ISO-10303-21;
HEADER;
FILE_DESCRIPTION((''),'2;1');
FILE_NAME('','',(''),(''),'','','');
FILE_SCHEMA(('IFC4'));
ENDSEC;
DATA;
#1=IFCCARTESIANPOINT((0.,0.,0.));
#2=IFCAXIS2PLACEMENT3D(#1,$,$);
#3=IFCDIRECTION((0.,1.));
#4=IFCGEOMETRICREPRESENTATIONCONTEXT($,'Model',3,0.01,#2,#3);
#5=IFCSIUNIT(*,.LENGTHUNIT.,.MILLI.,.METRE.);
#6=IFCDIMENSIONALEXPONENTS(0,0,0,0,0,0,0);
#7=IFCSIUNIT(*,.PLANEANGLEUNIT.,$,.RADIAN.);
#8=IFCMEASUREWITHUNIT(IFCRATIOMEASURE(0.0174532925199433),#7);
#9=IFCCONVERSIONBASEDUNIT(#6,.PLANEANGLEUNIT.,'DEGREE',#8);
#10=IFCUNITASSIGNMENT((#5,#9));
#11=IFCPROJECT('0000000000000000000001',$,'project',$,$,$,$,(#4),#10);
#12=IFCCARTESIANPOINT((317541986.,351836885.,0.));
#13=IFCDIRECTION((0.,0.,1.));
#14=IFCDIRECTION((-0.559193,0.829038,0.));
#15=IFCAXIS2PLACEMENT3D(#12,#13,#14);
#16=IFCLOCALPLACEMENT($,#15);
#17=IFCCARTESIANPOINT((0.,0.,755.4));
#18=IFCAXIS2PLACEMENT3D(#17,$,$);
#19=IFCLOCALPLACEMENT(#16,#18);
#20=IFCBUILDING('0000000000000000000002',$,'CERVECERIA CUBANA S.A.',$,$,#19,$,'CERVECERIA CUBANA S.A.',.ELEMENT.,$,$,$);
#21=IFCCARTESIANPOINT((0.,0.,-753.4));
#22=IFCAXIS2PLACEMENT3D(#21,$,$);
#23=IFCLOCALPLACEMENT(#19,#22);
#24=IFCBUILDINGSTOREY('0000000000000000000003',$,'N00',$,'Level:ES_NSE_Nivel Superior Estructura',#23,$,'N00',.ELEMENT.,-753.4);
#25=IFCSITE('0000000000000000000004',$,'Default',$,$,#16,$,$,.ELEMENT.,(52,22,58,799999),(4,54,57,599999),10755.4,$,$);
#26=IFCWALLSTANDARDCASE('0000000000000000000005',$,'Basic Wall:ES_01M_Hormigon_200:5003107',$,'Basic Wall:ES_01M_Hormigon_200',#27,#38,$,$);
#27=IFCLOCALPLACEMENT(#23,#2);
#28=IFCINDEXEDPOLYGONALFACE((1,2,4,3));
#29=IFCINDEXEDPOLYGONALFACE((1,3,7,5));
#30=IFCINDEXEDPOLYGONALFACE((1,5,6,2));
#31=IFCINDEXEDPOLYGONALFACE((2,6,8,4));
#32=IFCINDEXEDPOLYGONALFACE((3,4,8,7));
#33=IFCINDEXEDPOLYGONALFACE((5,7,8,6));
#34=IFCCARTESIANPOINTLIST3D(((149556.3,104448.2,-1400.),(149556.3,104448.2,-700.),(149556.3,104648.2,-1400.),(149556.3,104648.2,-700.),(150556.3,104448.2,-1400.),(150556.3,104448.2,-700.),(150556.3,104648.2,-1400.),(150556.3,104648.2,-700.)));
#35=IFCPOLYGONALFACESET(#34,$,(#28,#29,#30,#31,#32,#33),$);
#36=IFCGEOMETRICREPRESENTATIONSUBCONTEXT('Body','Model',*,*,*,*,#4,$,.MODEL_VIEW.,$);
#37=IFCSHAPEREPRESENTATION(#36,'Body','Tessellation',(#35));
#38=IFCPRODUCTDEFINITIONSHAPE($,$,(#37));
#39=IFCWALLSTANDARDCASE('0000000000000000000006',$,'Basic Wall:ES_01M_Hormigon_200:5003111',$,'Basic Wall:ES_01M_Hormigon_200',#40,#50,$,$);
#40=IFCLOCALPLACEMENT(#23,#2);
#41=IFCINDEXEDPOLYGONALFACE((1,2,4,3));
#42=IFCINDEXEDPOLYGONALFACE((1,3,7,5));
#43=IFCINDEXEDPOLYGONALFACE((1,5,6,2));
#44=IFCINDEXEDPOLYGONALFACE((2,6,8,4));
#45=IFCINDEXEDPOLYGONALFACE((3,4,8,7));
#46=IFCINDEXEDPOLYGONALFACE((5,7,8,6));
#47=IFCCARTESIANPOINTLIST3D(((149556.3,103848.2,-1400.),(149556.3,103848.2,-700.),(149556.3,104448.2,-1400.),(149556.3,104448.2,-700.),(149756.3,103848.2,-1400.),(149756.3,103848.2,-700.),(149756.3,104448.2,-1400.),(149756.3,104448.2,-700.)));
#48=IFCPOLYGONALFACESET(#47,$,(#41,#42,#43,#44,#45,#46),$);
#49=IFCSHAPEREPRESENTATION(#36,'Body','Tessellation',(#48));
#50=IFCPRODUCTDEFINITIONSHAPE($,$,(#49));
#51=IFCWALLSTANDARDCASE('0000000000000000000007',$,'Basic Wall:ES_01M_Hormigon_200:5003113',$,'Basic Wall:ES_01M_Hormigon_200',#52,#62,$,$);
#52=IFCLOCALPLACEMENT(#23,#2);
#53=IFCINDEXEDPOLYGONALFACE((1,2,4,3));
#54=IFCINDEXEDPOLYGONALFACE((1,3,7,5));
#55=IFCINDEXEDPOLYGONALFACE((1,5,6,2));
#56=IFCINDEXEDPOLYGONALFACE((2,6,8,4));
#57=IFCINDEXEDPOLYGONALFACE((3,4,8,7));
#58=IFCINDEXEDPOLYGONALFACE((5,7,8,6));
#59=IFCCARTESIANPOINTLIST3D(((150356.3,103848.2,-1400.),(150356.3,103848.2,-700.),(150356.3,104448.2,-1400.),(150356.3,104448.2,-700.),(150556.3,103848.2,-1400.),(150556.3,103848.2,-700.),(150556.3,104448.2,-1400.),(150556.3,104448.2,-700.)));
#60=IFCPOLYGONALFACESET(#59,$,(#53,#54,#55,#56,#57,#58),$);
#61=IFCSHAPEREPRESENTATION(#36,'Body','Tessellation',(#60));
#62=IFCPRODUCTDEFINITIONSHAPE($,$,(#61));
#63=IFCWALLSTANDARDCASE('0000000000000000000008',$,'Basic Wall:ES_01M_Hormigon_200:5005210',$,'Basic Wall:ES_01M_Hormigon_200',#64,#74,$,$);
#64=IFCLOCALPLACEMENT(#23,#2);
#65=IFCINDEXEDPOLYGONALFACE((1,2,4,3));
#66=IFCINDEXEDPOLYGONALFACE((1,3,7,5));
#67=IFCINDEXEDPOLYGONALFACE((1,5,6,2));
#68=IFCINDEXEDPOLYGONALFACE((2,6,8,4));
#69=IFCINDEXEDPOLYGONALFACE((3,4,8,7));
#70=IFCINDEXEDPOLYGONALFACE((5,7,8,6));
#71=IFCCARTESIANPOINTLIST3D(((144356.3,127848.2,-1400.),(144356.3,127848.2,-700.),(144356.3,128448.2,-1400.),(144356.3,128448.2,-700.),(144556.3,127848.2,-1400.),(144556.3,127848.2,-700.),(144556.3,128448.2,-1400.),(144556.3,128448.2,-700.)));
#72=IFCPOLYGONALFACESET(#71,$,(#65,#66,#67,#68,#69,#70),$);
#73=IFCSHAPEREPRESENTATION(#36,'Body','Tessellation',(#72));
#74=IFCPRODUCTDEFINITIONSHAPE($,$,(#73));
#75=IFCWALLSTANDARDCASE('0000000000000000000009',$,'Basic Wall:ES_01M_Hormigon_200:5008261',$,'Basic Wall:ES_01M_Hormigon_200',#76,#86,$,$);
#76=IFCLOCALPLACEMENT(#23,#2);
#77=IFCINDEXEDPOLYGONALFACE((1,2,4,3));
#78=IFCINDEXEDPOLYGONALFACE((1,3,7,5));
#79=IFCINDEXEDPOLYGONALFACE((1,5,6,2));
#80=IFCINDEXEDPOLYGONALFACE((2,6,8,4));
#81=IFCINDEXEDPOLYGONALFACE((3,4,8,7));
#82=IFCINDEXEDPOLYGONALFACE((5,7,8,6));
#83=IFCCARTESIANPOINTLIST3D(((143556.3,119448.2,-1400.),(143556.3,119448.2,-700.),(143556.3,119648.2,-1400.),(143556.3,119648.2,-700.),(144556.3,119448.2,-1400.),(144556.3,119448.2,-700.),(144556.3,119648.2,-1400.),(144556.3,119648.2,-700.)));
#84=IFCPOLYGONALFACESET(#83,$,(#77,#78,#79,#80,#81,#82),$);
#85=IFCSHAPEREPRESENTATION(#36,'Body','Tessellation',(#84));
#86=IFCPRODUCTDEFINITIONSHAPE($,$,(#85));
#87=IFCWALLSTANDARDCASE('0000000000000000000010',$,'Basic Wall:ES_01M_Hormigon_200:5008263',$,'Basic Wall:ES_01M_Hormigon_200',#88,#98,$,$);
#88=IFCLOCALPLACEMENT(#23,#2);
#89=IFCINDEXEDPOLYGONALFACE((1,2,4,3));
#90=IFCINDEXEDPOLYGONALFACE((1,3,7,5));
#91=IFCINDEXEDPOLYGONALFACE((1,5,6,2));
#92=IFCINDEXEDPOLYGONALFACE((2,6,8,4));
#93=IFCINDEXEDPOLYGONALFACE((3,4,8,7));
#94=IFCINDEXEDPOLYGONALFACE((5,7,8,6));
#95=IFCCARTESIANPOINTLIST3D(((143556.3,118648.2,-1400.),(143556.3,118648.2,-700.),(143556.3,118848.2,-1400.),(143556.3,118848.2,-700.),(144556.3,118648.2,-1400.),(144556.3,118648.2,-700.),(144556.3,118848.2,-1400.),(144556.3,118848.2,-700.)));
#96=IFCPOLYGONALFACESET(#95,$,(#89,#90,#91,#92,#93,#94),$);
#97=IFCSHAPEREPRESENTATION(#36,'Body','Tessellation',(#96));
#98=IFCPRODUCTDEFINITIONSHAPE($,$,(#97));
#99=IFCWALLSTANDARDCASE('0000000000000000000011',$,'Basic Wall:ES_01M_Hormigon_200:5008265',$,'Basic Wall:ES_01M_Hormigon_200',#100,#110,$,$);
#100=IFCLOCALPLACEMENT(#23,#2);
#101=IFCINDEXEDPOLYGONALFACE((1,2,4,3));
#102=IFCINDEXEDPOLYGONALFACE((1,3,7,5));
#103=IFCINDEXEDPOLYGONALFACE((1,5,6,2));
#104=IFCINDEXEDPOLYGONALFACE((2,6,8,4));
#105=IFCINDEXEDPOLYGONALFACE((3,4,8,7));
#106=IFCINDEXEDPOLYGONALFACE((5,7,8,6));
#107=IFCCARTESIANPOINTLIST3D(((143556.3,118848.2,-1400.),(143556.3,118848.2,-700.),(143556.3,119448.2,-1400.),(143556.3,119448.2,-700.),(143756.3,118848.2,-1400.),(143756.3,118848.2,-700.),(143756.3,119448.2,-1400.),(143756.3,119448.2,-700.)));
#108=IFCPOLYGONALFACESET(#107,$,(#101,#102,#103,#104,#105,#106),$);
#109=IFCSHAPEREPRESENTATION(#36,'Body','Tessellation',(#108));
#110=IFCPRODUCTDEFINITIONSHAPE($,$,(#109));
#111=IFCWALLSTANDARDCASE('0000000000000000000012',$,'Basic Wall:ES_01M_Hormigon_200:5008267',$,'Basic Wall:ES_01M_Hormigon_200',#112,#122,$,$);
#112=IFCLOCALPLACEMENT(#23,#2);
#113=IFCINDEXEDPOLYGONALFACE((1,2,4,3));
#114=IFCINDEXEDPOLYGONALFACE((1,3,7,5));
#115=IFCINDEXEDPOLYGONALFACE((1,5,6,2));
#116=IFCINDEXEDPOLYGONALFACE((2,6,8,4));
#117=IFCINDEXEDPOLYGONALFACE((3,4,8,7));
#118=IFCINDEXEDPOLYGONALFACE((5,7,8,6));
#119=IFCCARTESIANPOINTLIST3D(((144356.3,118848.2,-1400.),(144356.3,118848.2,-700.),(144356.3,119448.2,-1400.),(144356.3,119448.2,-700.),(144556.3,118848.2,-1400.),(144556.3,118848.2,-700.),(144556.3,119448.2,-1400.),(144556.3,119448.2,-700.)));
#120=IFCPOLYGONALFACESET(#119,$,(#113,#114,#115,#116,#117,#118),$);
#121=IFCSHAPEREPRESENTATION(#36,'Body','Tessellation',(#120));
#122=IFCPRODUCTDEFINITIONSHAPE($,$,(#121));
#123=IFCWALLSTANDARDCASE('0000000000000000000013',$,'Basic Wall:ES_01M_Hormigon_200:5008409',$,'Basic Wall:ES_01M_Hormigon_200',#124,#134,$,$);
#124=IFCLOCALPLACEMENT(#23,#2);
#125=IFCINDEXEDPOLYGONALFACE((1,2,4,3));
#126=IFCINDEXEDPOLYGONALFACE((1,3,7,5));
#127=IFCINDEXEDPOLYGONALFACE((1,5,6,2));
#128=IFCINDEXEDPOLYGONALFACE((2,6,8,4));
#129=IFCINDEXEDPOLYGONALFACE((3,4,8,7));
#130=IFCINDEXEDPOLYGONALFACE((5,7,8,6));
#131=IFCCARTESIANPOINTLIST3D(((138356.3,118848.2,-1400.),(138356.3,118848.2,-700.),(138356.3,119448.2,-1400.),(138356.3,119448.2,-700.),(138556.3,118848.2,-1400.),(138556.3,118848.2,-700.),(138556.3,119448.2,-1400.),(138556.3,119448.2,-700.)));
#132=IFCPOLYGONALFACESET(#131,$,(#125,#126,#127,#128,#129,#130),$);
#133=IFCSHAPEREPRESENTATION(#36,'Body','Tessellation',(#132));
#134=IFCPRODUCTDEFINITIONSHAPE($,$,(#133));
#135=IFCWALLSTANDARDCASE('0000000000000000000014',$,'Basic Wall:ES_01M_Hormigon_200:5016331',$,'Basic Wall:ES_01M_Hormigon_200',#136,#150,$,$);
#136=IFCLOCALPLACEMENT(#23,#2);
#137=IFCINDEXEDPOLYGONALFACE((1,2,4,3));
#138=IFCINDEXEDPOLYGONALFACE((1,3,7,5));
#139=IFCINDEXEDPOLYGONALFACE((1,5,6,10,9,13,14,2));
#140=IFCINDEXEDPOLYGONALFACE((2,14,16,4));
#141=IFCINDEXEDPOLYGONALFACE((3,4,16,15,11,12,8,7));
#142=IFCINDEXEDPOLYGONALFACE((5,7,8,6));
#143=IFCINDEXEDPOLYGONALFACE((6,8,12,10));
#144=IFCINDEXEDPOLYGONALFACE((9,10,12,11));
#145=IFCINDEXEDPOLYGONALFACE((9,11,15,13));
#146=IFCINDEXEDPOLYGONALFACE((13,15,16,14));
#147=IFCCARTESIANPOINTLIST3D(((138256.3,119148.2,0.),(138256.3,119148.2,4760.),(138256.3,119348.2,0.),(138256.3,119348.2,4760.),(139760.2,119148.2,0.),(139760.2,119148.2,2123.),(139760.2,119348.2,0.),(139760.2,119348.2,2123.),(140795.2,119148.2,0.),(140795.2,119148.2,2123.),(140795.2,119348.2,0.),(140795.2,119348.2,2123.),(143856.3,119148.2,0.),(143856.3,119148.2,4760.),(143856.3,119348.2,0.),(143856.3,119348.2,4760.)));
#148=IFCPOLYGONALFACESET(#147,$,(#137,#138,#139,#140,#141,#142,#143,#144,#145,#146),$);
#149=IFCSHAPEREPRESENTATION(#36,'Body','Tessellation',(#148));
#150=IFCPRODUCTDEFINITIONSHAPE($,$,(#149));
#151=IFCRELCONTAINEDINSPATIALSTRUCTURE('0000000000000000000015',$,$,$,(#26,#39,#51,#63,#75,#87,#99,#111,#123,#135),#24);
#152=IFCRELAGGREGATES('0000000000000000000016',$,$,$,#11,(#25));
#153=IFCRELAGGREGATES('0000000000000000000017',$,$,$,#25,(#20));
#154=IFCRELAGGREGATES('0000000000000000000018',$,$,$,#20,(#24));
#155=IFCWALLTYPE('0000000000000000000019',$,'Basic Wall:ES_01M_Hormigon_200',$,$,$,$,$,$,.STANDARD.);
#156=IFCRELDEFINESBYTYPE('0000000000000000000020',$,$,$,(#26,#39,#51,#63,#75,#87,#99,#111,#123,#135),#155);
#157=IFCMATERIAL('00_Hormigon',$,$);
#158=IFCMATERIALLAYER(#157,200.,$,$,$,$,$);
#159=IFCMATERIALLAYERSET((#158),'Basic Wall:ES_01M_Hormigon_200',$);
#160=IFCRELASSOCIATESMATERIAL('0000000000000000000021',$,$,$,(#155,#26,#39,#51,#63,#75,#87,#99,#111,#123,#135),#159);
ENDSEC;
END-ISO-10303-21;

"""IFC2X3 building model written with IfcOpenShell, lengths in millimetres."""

from ifc_helpers import new_model, entity, si_unit, converted_unit, direction, frame, frame_2d, origin, place, context, subcontext, project, spatial, rectangle, extrude, material, layer, layer_set, layer_usage, type_object, element, save


model = new_model("IFC2X3")

# Units and contexts
model_context = context("Model", 3, precision=0.01, world=origin(), true_north=direction((0.0, 1.0)))
body_context = subcontext(model_context, "Body", "Model", "MODEL_VIEW")
ifc_project = project(units=[si_unit("LENGTHUNIT", "METRE", prefix="MILLI"), converted_unit("PLANEANGLEUNIT", "DEGREE", entity("IfcRatioMeasure", 0.0174532925199433), si_unit("PLANEANGLEUNIT", "RADIAN"), dimensions=[0, 0, 0, 0, 0, 0, 0])], contexts=[model_context])

# Site, building, storey
site_placement = place(None, frame((317541986.0, 351836885.0, 0.0), z_axis=(0.0, 0.0, 1.0), x_axis=(-0.559193, 0.829038, 0.0)))
site = spatial("IfcSite", under=ifc_project, at=site_placement, Name="Default", CompositionType="ELEMENT", RefLatitude=(52, 22, 58, 799999), RefLongitude=(4, 54, 57, 599999), RefElevation=10755.4)
building_placement = place(site_placement, frame((0.0, 0.0, 755.4)))
building = spatial("IfcBuilding", under=site, at=building_placement, Name="CERVECERIA CUBANA S.A.", LongName="CERVECERIA CUBANA S.A.", CompositionType="ELEMENT")
storey_placement = place(building_placement, frame((0.0, 0.0, -753.4)))
storey = spatial("IfcBuildingStorey", under=building, at=storey_placement, Name="N00", ObjectType="Level:ES_NSE_Nivel Superior Estructura", LongName="N00", CompositionType="ELEMENT", Elevation=-753.4)

# Walls
ifc_material = material(Name="00_Hormigon")
ifc_layer_1 = layer(ifc_material, 200.0)
ifc_layer_set_1 = layer_set([ifc_layer_1], Name="Basic Wall:ES_01M_Hormigon_200")
wall_type_1 = type_object("IfcWallType", Name="Basic Wall:ES_01M_Hormigon_200", PredefinedType="STANDARD", material=ifc_layer_set_1)
ifc_layer_usage_1 = layer_usage(ifc_layer_set_1, "AXIS2", "NEGATIVE", 100.0)
wall_1_placement = place(storey_placement, frame((149556.3, 104548.2, -1400.0)))
element("IfcWallStandardCase", 1, at=wall_1_placement, inside=storey, type_object=wall_type_1, material=ifc_layer_usage_1, Name="Basic Wall:ES_01M_Hormigon_200:5003107", ObjectType="Basic Wall:ES_01M_Hormigon_200", context=body_context, shape_type="SweptSolid", body=[
    extrude(rectangle(XDim=1000.0, YDim=200.0, at=frame_2d((500.0, 0.0), x_axis=(-1.0, 0.0))), origin(), (0.0, 0.0, 1.0), 700.0),
])
ifc_layer_usage_2 = layer_usage(ifc_layer_set_1, "AXIS2", "POSITIVE", -100.0)
wall_2_placement = place(storey_placement, frame((149656.3, 104448.2, -1400.0), z_axis=(0.0, 0.0, 1.0), x_axis=(0.0, -1.0, 0.0)))
element("IfcWallStandardCase", 2, at=wall_2_placement, inside=storey, type_object=wall_type_1, material=ifc_layer_usage_2, Name="Basic Wall:ES_01M_Hormigon_200:5003111", ObjectType="Basic Wall:ES_01M_Hormigon_200", context=body_context, shape_type="SweptSolid", body=[
    extrude(rectangle(XDim=600.0, YDim=200.0, at=frame_2d((300.0, 0.0), x_axis=(-1.0, 0.0))), origin(), (0.0, 0.0, 1.0), 700.0),
])
ifc_layer_usage_3 = layer_usage(ifc_layer_set_1, "AXIS2", "NEGATIVE", 100.0)
wall_3_placement = place(storey_placement, frame((150456.3, 104448.2, -1400.0), z_axis=(0.0, 0.0, 1.0), x_axis=(0.0, -1.0, 0.0)))
element("IfcWallStandardCase", 3, at=wall_3_placement, inside=storey, type_object=wall_type_1, material=ifc_layer_usage_3, Name="Basic Wall:ES_01M_Hormigon_200:5003113", ObjectType="Basic Wall:ES_01M_Hormigon_200", context=body_context, shape_type="SweptSolid", body=[
    extrude(rectangle(XDim=600.0, YDim=200.0, at=frame_2d((300.0, 0.0), x_axis=(-1.0, 0.0))), origin(), (0.0, 0.0, 1.0), 700.0),
])
ifc_layer_usage_4 = layer_usage(ifc_layer_set_1, "AXIS2", "NEGATIVE", 100.0)
wall_4_placement = place(storey_placement, frame((144456.3, 128448.2, -1400.0), z_axis=(0.0, 0.0, 1.0), x_axis=(0.0, -1.0, 0.0)))
element("IfcWallStandardCase", 4, at=wall_4_placement, inside=storey, type_object=wall_type_1, material=ifc_layer_usage_4, Name="Basic Wall:ES_01M_Hormigon_200:5005210", ObjectType="Basic Wall:ES_01M_Hormigon_200", context=body_context, shape_type="SweptSolid", body=[
    extrude(rectangle(XDim=600.0, YDim=200.0, at=frame_2d((300.0, 0.0), x_axis=(-1.0, 0.0))), origin(), (0.0, 0.0, 1.0), 700.0),
])
ifc_layer_usage_5 = layer_usage(ifc_layer_set_1, "AXIS2", "NEGATIVE", 100.0)
wall_5_placement = place(storey_placement, frame((143556.3, 119548.2, -1400.0)))
element("IfcWallStandardCase", 5, at=wall_5_placement, inside=storey, type_object=wall_type_1, material=ifc_layer_usage_5, Name="Basic Wall:ES_01M_Hormigon_200:5008261", ObjectType="Basic Wall:ES_01M_Hormigon_200", context=body_context, shape_type="SweptSolid", body=[
    extrude(rectangle(XDim=1000.0, YDim=200.0, at=frame_2d((500.0, 0.0), x_axis=(-1.0, 0.0))), origin(), (0.0, 0.0, 1.0), 700.0),
])
ifc_layer_usage_6 = layer_usage(ifc_layer_set_1, "AXIS2", "POSITIVE", -100.0)
wall_6_placement = place(storey_placement, frame((143556.3, 118748.2, -1400.0)))
element("IfcWallStandardCase", 6, at=wall_6_placement, inside=storey, type_object=wall_type_1, material=ifc_layer_usage_6, Name="Basic Wall:ES_01M_Hormigon_200:5008263", ObjectType="Basic Wall:ES_01M_Hormigon_200", context=body_context, shape_type="SweptSolid", body=[
    extrude(rectangle(XDim=1000.0, YDim=200.0, at=frame_2d((500.0, 0.0), x_axis=(-1.0, 0.0))), origin(), (0.0, 0.0, 1.0), 700.0),
])
ifc_layer_usage_7 = layer_usage(ifc_layer_set_1, "AXIS2", "POSITIVE", -100.0)
wall_7_placement = place(storey_placement, frame((143656.3, 119448.2, -1400.0), z_axis=(0.0, 0.0, 1.0), x_axis=(0.0, -1.0, 0.0)))
element("IfcWallStandardCase", 7, at=wall_7_placement, inside=storey, type_object=wall_type_1, material=ifc_layer_usage_7, Name="Basic Wall:ES_01M_Hormigon_200:5008265", ObjectType="Basic Wall:ES_01M_Hormigon_200", context=body_context, shape_type="SweptSolid", body=[
    extrude(rectangle(XDim=600.0, YDim=200.0, at=frame_2d((300.0, 0.0), x_axis=(-1.0, 0.0))), origin(), (0.0, 0.0, 1.0), 700.0),
])
ifc_layer_usage_8 = layer_usage(ifc_layer_set_1, "AXIS2", "NEGATIVE", 100.0)
wall_8_placement = place(storey_placement, frame((144456.3, 119448.2, -1400.0), z_axis=(0.0, 0.0, 1.0), x_axis=(0.0, -1.0, 0.0)))
element("IfcWallStandardCase", 8, at=wall_8_placement, inside=storey, type_object=wall_type_1, material=ifc_layer_usage_8, Name="Basic Wall:ES_01M_Hormigon_200:5008267", ObjectType="Basic Wall:ES_01M_Hormigon_200", context=body_context, shape_type="SweptSolid", body=[
    extrude(rectangle(XDim=600.0, YDim=200.0, at=frame_2d((300.0, 0.0), x_axis=(-1.0, 0.0))), origin(), (0.0, 0.0, 1.0), 700.0),
])
ifc_layer_usage_9 = layer_usage(ifc_layer_set_1, "AXIS2", "NEGATIVE", 100.0)
wall_9_placement = place(storey_placement, frame((138456.3, 119448.2, -1400.0), z_axis=(0.0, 0.0, 1.0), x_axis=(0.0, -1.0, 0.0)))
element("IfcWallStandardCase", 9, at=wall_9_placement, inside=storey, type_object=wall_type_1, material=ifc_layer_usage_9, Name="Basic Wall:ES_01M_Hormigon_200:5008409", ObjectType="Basic Wall:ES_01M_Hormigon_200", context=body_context, shape_type="SweptSolid", body=[
    extrude(rectangle(XDim=600.0, YDim=200.0, at=frame_2d((300.0, 0.0), x_axis=(-1.0, 0.0))), origin(), (0.0, 0.0, 1.0), 700.0),
])

# Wall, opening
ifc_layer_usage_10 = layer_usage(ifc_layer_set_1, "AXIS2", "NEGATIVE", 100.0)
wall_10_placement = place(storey_placement, frame((138256.3, 119248.2, 0.0)))
wall_10 = element("IfcWallStandardCase", 10, at=wall_10_placement, inside=storey, type_object=wall_type_1, material=ifc_layer_usage_10, Name="Basic Wall:ES_01M_Hormigon_200:5016331", ObjectType="Basic Wall:ES_01M_Hormigon_200", context=body_context, shape_type="SweptSolid", body=[
    extrude(rectangle(XDim=5600.0, YDim=200.0, at=frame_2d((2800.0, 0.0), x_axis=(-1.0, 0.0))), origin(), (0.0, 0.0, 1.0), 4760.0),
])
opening_1_placement = place(wall_10_placement, frame((-138256.3, -119248.2, 0.0)))
element("IfcOpeningElement", 11, at=opening_1_placement, cuts=wall_10, ObjectType="Opening", context=body_context, shape_type="SweptSolid", body=[
    extrude(rectangle(XDim=2123.0, YDim=1035.0, at=frame_2d((0.0, 0.0), x_axis=(1.0, 0.0))), frame((140277.7, 117824.2, 1061.5), z_axis=(0.0, 1.0, 0.0), x_axis=(0.0, 0.0, -1.0)), (0.0, 0.0, 1.0), 3048.0),
])

save(model, "model.ifc")
